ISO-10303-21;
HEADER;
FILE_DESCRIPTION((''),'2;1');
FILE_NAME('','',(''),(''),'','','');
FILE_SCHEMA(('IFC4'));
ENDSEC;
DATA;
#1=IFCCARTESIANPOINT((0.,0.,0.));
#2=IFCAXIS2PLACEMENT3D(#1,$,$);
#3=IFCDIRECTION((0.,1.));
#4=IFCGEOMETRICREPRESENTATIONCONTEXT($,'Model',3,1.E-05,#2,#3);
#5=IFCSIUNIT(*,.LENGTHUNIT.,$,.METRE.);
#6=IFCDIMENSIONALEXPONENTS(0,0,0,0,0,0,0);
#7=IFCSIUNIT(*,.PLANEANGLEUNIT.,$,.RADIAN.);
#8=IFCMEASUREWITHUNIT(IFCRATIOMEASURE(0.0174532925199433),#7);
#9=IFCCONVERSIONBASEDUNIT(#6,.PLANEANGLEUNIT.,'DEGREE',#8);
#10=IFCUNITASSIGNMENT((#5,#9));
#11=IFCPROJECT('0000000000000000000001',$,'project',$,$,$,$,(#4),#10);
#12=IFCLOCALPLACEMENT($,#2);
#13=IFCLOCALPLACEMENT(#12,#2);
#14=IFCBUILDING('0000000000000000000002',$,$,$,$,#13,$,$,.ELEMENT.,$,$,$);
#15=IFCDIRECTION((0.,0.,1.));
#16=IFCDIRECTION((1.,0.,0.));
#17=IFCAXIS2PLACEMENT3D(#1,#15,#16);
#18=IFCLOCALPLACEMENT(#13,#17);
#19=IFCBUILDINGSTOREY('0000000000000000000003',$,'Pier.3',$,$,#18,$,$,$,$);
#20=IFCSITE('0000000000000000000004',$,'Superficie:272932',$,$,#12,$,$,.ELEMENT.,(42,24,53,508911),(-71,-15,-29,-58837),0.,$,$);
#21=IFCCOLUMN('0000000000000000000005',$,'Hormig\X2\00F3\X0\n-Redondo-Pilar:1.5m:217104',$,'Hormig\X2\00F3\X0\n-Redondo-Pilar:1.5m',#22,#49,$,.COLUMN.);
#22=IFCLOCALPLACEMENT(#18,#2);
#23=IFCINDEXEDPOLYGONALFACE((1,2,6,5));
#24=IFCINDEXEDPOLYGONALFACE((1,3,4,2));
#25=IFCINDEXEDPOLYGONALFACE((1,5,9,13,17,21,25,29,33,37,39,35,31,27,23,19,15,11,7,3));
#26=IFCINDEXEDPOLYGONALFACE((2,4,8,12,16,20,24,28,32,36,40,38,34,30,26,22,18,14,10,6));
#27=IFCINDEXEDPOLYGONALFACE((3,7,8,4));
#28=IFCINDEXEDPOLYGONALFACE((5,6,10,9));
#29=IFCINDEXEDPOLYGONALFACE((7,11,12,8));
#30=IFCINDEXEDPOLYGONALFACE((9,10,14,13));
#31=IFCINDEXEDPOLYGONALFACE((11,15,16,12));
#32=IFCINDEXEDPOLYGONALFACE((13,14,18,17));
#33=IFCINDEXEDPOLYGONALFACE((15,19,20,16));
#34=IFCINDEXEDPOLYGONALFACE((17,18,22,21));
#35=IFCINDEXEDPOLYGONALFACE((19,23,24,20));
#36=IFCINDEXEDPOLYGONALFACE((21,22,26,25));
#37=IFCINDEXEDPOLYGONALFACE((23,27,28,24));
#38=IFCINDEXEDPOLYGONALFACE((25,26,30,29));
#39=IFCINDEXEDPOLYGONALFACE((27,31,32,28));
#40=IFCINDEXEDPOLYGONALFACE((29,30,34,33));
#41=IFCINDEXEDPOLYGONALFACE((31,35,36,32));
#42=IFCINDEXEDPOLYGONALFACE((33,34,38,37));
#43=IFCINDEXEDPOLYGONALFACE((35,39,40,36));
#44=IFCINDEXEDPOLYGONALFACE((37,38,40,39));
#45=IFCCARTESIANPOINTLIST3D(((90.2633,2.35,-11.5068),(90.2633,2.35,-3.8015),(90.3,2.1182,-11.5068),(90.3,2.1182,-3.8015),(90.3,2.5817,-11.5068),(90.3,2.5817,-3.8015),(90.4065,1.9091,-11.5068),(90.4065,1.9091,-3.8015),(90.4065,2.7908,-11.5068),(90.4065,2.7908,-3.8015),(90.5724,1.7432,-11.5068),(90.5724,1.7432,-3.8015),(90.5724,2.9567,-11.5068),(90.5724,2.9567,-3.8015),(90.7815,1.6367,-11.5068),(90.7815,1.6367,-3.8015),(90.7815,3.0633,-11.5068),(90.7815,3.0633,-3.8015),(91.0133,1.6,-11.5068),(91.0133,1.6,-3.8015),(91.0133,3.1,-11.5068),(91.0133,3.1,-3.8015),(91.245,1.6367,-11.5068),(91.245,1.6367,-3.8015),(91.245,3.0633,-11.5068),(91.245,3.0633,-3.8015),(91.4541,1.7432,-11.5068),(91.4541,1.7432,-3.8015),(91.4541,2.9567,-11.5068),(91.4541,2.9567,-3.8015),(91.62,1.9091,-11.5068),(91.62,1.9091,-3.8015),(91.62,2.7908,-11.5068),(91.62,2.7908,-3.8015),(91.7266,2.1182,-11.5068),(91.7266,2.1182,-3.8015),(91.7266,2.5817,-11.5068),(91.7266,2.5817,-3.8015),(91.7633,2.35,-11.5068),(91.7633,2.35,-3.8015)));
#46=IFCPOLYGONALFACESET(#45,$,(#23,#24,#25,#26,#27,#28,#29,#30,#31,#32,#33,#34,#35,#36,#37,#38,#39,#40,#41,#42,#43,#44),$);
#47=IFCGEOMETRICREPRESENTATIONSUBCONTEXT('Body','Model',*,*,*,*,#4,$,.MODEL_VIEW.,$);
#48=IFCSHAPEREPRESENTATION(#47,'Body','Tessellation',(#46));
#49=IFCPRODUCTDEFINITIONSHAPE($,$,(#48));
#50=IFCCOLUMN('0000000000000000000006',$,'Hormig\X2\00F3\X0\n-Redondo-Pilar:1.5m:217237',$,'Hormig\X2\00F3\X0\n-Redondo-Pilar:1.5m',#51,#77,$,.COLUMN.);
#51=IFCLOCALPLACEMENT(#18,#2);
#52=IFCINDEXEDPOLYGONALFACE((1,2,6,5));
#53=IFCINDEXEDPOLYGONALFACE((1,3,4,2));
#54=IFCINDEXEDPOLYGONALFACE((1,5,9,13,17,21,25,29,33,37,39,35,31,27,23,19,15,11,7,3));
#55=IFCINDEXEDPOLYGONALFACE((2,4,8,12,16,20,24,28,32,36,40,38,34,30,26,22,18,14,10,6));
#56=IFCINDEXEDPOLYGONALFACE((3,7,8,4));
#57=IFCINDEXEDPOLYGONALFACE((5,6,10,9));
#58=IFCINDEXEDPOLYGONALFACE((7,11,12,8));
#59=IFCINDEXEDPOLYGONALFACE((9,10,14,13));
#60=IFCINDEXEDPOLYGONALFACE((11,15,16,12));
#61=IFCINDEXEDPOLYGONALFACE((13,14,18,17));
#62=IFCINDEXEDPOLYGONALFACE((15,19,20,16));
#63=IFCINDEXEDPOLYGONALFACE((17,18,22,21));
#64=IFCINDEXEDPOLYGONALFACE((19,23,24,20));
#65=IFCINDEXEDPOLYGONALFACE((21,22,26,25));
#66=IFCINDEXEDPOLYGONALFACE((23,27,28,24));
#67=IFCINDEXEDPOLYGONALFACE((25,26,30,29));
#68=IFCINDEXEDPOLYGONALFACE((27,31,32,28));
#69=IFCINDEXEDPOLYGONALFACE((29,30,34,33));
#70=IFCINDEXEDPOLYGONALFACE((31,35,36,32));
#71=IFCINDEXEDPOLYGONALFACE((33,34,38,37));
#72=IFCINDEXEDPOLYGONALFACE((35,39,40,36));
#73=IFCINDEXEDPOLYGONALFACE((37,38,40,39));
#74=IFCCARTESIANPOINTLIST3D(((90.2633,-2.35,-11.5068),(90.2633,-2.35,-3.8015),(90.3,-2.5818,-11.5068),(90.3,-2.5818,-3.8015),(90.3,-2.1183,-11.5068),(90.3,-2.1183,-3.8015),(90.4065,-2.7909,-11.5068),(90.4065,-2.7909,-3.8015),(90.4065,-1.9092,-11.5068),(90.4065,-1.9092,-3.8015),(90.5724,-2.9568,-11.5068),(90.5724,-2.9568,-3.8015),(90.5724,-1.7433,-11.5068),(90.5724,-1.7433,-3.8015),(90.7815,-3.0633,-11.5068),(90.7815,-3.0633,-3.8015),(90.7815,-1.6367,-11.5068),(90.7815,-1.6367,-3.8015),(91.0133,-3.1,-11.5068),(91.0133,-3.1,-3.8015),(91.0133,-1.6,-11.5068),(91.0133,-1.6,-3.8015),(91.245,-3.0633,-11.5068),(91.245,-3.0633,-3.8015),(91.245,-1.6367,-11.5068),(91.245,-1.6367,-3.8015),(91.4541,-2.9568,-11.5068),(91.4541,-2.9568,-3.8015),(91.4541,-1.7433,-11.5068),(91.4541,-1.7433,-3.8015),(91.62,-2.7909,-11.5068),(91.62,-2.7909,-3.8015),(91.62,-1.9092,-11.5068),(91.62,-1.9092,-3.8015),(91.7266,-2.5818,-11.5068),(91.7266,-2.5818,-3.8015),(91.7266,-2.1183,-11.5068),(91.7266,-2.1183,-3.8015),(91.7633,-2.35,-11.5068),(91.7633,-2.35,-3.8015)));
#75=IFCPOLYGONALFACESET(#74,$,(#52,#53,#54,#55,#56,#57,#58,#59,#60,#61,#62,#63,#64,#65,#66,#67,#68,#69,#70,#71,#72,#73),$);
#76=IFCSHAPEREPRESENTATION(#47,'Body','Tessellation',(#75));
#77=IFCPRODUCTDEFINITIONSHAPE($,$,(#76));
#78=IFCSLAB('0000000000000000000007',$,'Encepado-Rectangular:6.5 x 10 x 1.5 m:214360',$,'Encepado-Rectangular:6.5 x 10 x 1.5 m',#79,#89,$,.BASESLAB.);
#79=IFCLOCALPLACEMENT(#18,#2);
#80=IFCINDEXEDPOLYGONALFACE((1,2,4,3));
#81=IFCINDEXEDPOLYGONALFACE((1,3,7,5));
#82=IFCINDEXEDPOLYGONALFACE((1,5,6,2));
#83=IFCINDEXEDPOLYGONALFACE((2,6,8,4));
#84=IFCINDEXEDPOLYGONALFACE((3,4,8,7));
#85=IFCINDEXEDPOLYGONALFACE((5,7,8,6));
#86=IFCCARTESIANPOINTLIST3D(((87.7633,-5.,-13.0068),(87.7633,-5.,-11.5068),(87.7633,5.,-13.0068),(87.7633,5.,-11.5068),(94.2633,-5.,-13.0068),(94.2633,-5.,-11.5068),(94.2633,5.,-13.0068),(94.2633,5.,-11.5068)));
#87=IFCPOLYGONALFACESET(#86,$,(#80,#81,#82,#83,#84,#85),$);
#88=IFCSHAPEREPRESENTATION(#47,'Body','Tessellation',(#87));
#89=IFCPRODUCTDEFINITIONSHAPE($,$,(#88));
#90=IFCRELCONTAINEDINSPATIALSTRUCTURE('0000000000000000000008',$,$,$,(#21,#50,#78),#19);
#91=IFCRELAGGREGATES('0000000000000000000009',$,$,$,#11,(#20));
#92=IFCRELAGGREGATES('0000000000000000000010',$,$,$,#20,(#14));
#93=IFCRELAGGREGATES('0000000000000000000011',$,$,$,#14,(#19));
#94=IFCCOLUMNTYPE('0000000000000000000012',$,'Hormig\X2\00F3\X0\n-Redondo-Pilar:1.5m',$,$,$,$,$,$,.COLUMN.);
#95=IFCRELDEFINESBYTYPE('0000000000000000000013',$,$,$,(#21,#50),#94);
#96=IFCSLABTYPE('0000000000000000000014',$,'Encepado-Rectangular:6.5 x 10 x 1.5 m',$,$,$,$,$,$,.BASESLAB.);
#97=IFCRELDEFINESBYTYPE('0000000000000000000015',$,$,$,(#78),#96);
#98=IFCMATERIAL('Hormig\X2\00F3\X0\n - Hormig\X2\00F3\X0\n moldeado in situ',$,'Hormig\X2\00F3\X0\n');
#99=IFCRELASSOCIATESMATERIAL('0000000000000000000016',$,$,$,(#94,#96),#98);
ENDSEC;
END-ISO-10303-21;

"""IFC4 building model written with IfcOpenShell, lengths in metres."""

from ifc_helpers import new_model, entity, si_unit, converted_unit, direction, frame, origin, origin_with_axes, place, context, subcontext, project, spatial, indexed_curve, outline, extrude, source, transform, mapped, material, type_object, type_shapes, element, save


model = new_model("IFC4")

# Units and contexts
model_context = context("Model", 3, precision=1e-05, world=origin(), true_north=direction((0.0, 1.0)))
body_context = subcontext(model_context, "Body", "Model", "MODEL_VIEW")
ifc_project = project(units=[si_unit("LENGTHUNIT", "METRE"), converted_unit("PLANEANGLEUNIT", "DEGREE", entity("IfcRatioMeasure", 0.0174532925199433), si_unit("PLANEANGLEUNIT", "RADIAN"), dimensions=[0, 0, 0, 0, 0, 0, 0])], contexts=[model_context])

# Site, building, storey
site_placement = place(None, origin())
site = spatial("IfcSite", under=ifc_project, at=site_placement, Name="Superficie:272932", CompositionType="ELEMENT", RefLatitude=(42, 24, 53, 508911), RefLongitude=(-71, -15, -29, -58837), RefElevation=0.0)
building_placement = place(site_placement, origin())
building = spatial("IfcBuilding", under=site, at=building_placement, CompositionType="ELEMENT")
storey_placement = place(building_placement, origin_with_axes())
storey = spatial("IfcBuildingStorey", under=building, at=storey_placement, Name="Pier.3")

# Columns
ifc_material = material(Name="Hormigón - Hormigón moldeado in situ", Category="Hormigón")
column_type = type_object("IfcColumnType", Name="Hormigón-Redondo-Pilar:1.5m", PredefinedType="COLUMN", material=ifc_material)
shared_shape = source(origin(), body_context, "Body", "SweptSolid", [
    extrude(outline(indexed_curve([(0.75, 0.0), (0.7133, 0.2318), (0.6068, 0.4408), (0.4408, 0.6068), (0.2318, 0.7133), (0.0, 0.75), (-0.2318, 0.7133), (-0.4408, 0.6068), (-0.6068, 0.4408), (-0.7133, 0.2318), (-0.75, 0.0), (-0.7133, -0.2318), (-0.6068, -0.4408), (-0.4408, -0.6068), (-0.2318, -0.7133), (0.0, -0.75), (0.2318, -0.7133), (0.4408, -0.6068), (0.6068, -0.4408), (0.7133, -0.2318), (0.75, 0.0)], self_intersect=False)), frame((0.0, 0.0, -11.5068)), (0.0, 0.0, 1.0), 7.7053),
])
type_shapes(column_type, [shared_shape])
for number, where, z_axis, x_axis, name in (
    (1, (91.0133, 2.35, 0.0), (0.0, 0.0, 1.0), (1.0, 0.0, 0.0), "Hormigón-Redondo-Pilar:1.5m:217104"),
    (2, (91.0133, -2.35, 0.0), (0.0, 0.0, 1.0), (1.0, 0.0, 0.0), "Hormigón-Redondo-Pilar:1.5m:217237"),
):
    element("IfcColumn", number, at=place(storey_placement, frame(where, z_axis=z_axis, x_axis=x_axis)), inside=storey, type_object=column_type, Name=name, ObjectType="Hormigón-Redondo-Pilar:1.5m", PredefinedType="COLUMN", context=body_context, shape_type="MappedRepresentation", body=[
        mapped(shared_shape, transform((0.0, 0.0, 0.0), scale=1.0)),
    ])

# Slab
slab_type = type_object("IfcSlabType", Name="Encepado-Rectangular:6.5 x 10 x 1.5 m", PredefinedType="BASESLAB", material=ifc_material)
slab_placement = place(storey_placement, frame((0.0, 0.0, -11.5068), z_axis=(0.0, 0.0, 1.0), x_axis=(1.0, 0.0, 0.0)))
element("IfcSlab", 3, at=slab_placement, inside=storey, type_object=slab_type, Name="Encepado-Rectangular:6.5 x 10 x 1.5 m:214360", ObjectType="Encepado-Rectangular:6.5 x 10 x 1.5 m", PredefinedType="BASESLAB", context=body_context, shape_type="SweptSolid", body=[
    extrude(outline(indexed_curve([(-3.25, -5.0), (3.25, -5.0), (3.25, 5.0), (-3.25, 5.0), (-3.25, -5.0)], self_intersect=False)), frame((91.0133, 0.0, -1.5), z_axis=(0.0, 0.0, 1.0), x_axis=(-1.0, 0.0, 0.0)), (0.0, 0.0, 1.0), 1.5),
])

save(model, "model.ifc")
